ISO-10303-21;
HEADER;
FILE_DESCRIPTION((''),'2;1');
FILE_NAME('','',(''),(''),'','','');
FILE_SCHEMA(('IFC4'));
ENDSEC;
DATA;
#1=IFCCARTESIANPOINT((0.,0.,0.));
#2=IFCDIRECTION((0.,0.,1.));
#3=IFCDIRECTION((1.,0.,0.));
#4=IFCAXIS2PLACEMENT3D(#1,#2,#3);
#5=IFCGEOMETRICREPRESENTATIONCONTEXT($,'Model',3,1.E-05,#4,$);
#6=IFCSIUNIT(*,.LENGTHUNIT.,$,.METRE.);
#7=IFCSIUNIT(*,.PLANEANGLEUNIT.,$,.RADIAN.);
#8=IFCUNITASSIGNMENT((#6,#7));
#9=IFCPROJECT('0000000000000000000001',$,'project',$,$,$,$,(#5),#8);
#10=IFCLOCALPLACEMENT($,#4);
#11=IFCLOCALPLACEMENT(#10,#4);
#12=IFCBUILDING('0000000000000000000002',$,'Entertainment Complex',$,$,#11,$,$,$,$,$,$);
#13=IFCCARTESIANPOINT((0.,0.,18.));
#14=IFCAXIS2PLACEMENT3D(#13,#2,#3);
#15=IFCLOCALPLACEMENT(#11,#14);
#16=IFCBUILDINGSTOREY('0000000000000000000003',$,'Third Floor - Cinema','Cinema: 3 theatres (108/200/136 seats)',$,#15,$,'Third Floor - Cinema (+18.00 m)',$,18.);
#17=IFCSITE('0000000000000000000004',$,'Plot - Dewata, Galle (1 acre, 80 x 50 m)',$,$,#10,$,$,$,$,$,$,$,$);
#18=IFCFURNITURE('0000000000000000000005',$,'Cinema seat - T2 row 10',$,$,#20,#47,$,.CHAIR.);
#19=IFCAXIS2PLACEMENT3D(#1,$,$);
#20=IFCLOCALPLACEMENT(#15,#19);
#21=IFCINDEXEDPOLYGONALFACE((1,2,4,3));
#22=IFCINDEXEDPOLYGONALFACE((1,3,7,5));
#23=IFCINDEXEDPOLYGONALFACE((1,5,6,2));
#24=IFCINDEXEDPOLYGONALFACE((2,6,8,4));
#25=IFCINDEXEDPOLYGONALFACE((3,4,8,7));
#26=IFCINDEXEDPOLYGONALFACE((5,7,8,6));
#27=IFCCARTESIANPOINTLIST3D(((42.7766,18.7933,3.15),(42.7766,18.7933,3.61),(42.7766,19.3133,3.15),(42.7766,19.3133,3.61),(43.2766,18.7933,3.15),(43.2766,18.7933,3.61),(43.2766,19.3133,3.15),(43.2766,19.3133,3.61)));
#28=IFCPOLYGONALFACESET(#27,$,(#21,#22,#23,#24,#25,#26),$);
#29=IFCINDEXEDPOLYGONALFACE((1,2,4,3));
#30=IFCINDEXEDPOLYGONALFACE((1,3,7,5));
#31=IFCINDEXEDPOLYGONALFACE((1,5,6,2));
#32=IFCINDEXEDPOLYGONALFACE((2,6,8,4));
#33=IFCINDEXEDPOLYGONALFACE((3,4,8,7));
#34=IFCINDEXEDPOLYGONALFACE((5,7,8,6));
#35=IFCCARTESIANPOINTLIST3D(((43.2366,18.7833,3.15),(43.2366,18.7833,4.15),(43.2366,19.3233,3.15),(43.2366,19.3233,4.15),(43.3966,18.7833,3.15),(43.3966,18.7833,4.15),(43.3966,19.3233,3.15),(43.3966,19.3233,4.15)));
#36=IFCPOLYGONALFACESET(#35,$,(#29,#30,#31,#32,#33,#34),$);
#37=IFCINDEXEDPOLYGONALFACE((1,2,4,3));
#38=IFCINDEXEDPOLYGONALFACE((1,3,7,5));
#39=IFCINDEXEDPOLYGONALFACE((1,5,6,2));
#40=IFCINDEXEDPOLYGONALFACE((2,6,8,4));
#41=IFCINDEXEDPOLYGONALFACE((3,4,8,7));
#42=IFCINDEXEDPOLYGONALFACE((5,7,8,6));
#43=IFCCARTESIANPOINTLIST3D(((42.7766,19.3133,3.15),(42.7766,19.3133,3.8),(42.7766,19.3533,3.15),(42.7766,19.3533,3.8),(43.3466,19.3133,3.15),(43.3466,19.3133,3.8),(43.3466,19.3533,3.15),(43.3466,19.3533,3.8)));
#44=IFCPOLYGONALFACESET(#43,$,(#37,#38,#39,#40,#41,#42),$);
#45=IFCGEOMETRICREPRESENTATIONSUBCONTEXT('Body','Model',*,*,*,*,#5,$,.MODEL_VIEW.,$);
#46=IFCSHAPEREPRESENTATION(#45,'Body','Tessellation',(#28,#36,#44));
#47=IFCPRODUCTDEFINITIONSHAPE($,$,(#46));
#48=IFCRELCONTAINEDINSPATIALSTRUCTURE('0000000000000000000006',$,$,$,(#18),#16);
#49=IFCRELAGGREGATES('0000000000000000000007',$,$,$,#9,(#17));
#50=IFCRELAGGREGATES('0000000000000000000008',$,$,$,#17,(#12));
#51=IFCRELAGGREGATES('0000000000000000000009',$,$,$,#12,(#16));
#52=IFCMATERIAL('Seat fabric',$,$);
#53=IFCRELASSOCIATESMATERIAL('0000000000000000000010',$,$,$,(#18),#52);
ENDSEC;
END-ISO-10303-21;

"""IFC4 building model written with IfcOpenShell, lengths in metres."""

from ifc_helpers import new_model, si_unit, frame, origin_with_axes, place, context, subcontext, project, spatial, polyline, outline, extrude, material, element, save


model = new_model("IFC4")

# Units and contexts
model_context = context("Model", 3, precision=1e-05, world=origin_with_axes())
body_context = subcontext(model_context, "Body", "Model", "MODEL_VIEW")
ifc_project = project(units=[si_unit("LENGTHUNIT", "METRE"), si_unit("PLANEANGLEUNIT", "RADIAN")], contexts=[model_context])

# Site, building, storey
site_placement = place(None, origin_with_axes())
site = spatial("IfcSite", under=ifc_project, at=site_placement, Name="Plot - Dewata, Galle (1 acre, 80 x 50 m)")
building_placement = place(site_placement, origin_with_axes())
building = spatial("IfcBuilding", under=site, at=building_placement, Name="Entertainment Complex")
storey_placement = place(building_placement, frame((0.0, 0.0, 18.0), z_axis=(0.0, 0.0, 1.0), x_axis=(1.0, 0.0, 0.0)))
storey = spatial("IfcBuildingStorey", under=building, at=storey_placement, Name="Third Floor - Cinema", Description="Cinema: 3 theatres (108/200/136 seats)", LongName="Third Floor - Cinema (+18.00 m)", Elevation=18.0)

# Furniture
ifc_material_1 = material(Name="Seat fabric")
for number, where, z_axis, x_axis, name in (
    (1, (43.3966, 19.0533, 3.15), (0.0, 0.0, 1.0), (1.0, 0.0, 0.0), "Cinema seat - T2 row 10"),
):
    element("IfcFurniture", number, at=place(storey_placement, frame(where, z_axis=z_axis, x_axis=x_axis)), inside=storey, material=ifc_material_1, Name=name, PredefinedType="CHAIR", context=body_context, shape_type="SweptSolid", body=[
        extrude(outline(polyline([(-0.62, -0.26), (-0.12, -0.26), (-0.12, 0.26), (-0.62, 0.26), (-0.62, -0.26)])), origin_with_axes(), (0.0, 0.0, 1.0), 0.46),
        extrude(outline(polyline([(-0.16, -0.27), (0.0, -0.27), (0.0, 0.27), (-0.16, 0.27), (-0.16, -0.27)])), origin_with_axes(), (0.0, 0.0, 1.0), 1.0),
        extrude(outline(polyline([(-0.62, 0.26), (-0.05, 0.26), (-0.05, 0.3), (-0.62, 0.3), (-0.62, 0.26)])), origin_with_axes(), (0.0, 0.0, 1.0), 0.65),
    ])

save(model, "model.ifc")
